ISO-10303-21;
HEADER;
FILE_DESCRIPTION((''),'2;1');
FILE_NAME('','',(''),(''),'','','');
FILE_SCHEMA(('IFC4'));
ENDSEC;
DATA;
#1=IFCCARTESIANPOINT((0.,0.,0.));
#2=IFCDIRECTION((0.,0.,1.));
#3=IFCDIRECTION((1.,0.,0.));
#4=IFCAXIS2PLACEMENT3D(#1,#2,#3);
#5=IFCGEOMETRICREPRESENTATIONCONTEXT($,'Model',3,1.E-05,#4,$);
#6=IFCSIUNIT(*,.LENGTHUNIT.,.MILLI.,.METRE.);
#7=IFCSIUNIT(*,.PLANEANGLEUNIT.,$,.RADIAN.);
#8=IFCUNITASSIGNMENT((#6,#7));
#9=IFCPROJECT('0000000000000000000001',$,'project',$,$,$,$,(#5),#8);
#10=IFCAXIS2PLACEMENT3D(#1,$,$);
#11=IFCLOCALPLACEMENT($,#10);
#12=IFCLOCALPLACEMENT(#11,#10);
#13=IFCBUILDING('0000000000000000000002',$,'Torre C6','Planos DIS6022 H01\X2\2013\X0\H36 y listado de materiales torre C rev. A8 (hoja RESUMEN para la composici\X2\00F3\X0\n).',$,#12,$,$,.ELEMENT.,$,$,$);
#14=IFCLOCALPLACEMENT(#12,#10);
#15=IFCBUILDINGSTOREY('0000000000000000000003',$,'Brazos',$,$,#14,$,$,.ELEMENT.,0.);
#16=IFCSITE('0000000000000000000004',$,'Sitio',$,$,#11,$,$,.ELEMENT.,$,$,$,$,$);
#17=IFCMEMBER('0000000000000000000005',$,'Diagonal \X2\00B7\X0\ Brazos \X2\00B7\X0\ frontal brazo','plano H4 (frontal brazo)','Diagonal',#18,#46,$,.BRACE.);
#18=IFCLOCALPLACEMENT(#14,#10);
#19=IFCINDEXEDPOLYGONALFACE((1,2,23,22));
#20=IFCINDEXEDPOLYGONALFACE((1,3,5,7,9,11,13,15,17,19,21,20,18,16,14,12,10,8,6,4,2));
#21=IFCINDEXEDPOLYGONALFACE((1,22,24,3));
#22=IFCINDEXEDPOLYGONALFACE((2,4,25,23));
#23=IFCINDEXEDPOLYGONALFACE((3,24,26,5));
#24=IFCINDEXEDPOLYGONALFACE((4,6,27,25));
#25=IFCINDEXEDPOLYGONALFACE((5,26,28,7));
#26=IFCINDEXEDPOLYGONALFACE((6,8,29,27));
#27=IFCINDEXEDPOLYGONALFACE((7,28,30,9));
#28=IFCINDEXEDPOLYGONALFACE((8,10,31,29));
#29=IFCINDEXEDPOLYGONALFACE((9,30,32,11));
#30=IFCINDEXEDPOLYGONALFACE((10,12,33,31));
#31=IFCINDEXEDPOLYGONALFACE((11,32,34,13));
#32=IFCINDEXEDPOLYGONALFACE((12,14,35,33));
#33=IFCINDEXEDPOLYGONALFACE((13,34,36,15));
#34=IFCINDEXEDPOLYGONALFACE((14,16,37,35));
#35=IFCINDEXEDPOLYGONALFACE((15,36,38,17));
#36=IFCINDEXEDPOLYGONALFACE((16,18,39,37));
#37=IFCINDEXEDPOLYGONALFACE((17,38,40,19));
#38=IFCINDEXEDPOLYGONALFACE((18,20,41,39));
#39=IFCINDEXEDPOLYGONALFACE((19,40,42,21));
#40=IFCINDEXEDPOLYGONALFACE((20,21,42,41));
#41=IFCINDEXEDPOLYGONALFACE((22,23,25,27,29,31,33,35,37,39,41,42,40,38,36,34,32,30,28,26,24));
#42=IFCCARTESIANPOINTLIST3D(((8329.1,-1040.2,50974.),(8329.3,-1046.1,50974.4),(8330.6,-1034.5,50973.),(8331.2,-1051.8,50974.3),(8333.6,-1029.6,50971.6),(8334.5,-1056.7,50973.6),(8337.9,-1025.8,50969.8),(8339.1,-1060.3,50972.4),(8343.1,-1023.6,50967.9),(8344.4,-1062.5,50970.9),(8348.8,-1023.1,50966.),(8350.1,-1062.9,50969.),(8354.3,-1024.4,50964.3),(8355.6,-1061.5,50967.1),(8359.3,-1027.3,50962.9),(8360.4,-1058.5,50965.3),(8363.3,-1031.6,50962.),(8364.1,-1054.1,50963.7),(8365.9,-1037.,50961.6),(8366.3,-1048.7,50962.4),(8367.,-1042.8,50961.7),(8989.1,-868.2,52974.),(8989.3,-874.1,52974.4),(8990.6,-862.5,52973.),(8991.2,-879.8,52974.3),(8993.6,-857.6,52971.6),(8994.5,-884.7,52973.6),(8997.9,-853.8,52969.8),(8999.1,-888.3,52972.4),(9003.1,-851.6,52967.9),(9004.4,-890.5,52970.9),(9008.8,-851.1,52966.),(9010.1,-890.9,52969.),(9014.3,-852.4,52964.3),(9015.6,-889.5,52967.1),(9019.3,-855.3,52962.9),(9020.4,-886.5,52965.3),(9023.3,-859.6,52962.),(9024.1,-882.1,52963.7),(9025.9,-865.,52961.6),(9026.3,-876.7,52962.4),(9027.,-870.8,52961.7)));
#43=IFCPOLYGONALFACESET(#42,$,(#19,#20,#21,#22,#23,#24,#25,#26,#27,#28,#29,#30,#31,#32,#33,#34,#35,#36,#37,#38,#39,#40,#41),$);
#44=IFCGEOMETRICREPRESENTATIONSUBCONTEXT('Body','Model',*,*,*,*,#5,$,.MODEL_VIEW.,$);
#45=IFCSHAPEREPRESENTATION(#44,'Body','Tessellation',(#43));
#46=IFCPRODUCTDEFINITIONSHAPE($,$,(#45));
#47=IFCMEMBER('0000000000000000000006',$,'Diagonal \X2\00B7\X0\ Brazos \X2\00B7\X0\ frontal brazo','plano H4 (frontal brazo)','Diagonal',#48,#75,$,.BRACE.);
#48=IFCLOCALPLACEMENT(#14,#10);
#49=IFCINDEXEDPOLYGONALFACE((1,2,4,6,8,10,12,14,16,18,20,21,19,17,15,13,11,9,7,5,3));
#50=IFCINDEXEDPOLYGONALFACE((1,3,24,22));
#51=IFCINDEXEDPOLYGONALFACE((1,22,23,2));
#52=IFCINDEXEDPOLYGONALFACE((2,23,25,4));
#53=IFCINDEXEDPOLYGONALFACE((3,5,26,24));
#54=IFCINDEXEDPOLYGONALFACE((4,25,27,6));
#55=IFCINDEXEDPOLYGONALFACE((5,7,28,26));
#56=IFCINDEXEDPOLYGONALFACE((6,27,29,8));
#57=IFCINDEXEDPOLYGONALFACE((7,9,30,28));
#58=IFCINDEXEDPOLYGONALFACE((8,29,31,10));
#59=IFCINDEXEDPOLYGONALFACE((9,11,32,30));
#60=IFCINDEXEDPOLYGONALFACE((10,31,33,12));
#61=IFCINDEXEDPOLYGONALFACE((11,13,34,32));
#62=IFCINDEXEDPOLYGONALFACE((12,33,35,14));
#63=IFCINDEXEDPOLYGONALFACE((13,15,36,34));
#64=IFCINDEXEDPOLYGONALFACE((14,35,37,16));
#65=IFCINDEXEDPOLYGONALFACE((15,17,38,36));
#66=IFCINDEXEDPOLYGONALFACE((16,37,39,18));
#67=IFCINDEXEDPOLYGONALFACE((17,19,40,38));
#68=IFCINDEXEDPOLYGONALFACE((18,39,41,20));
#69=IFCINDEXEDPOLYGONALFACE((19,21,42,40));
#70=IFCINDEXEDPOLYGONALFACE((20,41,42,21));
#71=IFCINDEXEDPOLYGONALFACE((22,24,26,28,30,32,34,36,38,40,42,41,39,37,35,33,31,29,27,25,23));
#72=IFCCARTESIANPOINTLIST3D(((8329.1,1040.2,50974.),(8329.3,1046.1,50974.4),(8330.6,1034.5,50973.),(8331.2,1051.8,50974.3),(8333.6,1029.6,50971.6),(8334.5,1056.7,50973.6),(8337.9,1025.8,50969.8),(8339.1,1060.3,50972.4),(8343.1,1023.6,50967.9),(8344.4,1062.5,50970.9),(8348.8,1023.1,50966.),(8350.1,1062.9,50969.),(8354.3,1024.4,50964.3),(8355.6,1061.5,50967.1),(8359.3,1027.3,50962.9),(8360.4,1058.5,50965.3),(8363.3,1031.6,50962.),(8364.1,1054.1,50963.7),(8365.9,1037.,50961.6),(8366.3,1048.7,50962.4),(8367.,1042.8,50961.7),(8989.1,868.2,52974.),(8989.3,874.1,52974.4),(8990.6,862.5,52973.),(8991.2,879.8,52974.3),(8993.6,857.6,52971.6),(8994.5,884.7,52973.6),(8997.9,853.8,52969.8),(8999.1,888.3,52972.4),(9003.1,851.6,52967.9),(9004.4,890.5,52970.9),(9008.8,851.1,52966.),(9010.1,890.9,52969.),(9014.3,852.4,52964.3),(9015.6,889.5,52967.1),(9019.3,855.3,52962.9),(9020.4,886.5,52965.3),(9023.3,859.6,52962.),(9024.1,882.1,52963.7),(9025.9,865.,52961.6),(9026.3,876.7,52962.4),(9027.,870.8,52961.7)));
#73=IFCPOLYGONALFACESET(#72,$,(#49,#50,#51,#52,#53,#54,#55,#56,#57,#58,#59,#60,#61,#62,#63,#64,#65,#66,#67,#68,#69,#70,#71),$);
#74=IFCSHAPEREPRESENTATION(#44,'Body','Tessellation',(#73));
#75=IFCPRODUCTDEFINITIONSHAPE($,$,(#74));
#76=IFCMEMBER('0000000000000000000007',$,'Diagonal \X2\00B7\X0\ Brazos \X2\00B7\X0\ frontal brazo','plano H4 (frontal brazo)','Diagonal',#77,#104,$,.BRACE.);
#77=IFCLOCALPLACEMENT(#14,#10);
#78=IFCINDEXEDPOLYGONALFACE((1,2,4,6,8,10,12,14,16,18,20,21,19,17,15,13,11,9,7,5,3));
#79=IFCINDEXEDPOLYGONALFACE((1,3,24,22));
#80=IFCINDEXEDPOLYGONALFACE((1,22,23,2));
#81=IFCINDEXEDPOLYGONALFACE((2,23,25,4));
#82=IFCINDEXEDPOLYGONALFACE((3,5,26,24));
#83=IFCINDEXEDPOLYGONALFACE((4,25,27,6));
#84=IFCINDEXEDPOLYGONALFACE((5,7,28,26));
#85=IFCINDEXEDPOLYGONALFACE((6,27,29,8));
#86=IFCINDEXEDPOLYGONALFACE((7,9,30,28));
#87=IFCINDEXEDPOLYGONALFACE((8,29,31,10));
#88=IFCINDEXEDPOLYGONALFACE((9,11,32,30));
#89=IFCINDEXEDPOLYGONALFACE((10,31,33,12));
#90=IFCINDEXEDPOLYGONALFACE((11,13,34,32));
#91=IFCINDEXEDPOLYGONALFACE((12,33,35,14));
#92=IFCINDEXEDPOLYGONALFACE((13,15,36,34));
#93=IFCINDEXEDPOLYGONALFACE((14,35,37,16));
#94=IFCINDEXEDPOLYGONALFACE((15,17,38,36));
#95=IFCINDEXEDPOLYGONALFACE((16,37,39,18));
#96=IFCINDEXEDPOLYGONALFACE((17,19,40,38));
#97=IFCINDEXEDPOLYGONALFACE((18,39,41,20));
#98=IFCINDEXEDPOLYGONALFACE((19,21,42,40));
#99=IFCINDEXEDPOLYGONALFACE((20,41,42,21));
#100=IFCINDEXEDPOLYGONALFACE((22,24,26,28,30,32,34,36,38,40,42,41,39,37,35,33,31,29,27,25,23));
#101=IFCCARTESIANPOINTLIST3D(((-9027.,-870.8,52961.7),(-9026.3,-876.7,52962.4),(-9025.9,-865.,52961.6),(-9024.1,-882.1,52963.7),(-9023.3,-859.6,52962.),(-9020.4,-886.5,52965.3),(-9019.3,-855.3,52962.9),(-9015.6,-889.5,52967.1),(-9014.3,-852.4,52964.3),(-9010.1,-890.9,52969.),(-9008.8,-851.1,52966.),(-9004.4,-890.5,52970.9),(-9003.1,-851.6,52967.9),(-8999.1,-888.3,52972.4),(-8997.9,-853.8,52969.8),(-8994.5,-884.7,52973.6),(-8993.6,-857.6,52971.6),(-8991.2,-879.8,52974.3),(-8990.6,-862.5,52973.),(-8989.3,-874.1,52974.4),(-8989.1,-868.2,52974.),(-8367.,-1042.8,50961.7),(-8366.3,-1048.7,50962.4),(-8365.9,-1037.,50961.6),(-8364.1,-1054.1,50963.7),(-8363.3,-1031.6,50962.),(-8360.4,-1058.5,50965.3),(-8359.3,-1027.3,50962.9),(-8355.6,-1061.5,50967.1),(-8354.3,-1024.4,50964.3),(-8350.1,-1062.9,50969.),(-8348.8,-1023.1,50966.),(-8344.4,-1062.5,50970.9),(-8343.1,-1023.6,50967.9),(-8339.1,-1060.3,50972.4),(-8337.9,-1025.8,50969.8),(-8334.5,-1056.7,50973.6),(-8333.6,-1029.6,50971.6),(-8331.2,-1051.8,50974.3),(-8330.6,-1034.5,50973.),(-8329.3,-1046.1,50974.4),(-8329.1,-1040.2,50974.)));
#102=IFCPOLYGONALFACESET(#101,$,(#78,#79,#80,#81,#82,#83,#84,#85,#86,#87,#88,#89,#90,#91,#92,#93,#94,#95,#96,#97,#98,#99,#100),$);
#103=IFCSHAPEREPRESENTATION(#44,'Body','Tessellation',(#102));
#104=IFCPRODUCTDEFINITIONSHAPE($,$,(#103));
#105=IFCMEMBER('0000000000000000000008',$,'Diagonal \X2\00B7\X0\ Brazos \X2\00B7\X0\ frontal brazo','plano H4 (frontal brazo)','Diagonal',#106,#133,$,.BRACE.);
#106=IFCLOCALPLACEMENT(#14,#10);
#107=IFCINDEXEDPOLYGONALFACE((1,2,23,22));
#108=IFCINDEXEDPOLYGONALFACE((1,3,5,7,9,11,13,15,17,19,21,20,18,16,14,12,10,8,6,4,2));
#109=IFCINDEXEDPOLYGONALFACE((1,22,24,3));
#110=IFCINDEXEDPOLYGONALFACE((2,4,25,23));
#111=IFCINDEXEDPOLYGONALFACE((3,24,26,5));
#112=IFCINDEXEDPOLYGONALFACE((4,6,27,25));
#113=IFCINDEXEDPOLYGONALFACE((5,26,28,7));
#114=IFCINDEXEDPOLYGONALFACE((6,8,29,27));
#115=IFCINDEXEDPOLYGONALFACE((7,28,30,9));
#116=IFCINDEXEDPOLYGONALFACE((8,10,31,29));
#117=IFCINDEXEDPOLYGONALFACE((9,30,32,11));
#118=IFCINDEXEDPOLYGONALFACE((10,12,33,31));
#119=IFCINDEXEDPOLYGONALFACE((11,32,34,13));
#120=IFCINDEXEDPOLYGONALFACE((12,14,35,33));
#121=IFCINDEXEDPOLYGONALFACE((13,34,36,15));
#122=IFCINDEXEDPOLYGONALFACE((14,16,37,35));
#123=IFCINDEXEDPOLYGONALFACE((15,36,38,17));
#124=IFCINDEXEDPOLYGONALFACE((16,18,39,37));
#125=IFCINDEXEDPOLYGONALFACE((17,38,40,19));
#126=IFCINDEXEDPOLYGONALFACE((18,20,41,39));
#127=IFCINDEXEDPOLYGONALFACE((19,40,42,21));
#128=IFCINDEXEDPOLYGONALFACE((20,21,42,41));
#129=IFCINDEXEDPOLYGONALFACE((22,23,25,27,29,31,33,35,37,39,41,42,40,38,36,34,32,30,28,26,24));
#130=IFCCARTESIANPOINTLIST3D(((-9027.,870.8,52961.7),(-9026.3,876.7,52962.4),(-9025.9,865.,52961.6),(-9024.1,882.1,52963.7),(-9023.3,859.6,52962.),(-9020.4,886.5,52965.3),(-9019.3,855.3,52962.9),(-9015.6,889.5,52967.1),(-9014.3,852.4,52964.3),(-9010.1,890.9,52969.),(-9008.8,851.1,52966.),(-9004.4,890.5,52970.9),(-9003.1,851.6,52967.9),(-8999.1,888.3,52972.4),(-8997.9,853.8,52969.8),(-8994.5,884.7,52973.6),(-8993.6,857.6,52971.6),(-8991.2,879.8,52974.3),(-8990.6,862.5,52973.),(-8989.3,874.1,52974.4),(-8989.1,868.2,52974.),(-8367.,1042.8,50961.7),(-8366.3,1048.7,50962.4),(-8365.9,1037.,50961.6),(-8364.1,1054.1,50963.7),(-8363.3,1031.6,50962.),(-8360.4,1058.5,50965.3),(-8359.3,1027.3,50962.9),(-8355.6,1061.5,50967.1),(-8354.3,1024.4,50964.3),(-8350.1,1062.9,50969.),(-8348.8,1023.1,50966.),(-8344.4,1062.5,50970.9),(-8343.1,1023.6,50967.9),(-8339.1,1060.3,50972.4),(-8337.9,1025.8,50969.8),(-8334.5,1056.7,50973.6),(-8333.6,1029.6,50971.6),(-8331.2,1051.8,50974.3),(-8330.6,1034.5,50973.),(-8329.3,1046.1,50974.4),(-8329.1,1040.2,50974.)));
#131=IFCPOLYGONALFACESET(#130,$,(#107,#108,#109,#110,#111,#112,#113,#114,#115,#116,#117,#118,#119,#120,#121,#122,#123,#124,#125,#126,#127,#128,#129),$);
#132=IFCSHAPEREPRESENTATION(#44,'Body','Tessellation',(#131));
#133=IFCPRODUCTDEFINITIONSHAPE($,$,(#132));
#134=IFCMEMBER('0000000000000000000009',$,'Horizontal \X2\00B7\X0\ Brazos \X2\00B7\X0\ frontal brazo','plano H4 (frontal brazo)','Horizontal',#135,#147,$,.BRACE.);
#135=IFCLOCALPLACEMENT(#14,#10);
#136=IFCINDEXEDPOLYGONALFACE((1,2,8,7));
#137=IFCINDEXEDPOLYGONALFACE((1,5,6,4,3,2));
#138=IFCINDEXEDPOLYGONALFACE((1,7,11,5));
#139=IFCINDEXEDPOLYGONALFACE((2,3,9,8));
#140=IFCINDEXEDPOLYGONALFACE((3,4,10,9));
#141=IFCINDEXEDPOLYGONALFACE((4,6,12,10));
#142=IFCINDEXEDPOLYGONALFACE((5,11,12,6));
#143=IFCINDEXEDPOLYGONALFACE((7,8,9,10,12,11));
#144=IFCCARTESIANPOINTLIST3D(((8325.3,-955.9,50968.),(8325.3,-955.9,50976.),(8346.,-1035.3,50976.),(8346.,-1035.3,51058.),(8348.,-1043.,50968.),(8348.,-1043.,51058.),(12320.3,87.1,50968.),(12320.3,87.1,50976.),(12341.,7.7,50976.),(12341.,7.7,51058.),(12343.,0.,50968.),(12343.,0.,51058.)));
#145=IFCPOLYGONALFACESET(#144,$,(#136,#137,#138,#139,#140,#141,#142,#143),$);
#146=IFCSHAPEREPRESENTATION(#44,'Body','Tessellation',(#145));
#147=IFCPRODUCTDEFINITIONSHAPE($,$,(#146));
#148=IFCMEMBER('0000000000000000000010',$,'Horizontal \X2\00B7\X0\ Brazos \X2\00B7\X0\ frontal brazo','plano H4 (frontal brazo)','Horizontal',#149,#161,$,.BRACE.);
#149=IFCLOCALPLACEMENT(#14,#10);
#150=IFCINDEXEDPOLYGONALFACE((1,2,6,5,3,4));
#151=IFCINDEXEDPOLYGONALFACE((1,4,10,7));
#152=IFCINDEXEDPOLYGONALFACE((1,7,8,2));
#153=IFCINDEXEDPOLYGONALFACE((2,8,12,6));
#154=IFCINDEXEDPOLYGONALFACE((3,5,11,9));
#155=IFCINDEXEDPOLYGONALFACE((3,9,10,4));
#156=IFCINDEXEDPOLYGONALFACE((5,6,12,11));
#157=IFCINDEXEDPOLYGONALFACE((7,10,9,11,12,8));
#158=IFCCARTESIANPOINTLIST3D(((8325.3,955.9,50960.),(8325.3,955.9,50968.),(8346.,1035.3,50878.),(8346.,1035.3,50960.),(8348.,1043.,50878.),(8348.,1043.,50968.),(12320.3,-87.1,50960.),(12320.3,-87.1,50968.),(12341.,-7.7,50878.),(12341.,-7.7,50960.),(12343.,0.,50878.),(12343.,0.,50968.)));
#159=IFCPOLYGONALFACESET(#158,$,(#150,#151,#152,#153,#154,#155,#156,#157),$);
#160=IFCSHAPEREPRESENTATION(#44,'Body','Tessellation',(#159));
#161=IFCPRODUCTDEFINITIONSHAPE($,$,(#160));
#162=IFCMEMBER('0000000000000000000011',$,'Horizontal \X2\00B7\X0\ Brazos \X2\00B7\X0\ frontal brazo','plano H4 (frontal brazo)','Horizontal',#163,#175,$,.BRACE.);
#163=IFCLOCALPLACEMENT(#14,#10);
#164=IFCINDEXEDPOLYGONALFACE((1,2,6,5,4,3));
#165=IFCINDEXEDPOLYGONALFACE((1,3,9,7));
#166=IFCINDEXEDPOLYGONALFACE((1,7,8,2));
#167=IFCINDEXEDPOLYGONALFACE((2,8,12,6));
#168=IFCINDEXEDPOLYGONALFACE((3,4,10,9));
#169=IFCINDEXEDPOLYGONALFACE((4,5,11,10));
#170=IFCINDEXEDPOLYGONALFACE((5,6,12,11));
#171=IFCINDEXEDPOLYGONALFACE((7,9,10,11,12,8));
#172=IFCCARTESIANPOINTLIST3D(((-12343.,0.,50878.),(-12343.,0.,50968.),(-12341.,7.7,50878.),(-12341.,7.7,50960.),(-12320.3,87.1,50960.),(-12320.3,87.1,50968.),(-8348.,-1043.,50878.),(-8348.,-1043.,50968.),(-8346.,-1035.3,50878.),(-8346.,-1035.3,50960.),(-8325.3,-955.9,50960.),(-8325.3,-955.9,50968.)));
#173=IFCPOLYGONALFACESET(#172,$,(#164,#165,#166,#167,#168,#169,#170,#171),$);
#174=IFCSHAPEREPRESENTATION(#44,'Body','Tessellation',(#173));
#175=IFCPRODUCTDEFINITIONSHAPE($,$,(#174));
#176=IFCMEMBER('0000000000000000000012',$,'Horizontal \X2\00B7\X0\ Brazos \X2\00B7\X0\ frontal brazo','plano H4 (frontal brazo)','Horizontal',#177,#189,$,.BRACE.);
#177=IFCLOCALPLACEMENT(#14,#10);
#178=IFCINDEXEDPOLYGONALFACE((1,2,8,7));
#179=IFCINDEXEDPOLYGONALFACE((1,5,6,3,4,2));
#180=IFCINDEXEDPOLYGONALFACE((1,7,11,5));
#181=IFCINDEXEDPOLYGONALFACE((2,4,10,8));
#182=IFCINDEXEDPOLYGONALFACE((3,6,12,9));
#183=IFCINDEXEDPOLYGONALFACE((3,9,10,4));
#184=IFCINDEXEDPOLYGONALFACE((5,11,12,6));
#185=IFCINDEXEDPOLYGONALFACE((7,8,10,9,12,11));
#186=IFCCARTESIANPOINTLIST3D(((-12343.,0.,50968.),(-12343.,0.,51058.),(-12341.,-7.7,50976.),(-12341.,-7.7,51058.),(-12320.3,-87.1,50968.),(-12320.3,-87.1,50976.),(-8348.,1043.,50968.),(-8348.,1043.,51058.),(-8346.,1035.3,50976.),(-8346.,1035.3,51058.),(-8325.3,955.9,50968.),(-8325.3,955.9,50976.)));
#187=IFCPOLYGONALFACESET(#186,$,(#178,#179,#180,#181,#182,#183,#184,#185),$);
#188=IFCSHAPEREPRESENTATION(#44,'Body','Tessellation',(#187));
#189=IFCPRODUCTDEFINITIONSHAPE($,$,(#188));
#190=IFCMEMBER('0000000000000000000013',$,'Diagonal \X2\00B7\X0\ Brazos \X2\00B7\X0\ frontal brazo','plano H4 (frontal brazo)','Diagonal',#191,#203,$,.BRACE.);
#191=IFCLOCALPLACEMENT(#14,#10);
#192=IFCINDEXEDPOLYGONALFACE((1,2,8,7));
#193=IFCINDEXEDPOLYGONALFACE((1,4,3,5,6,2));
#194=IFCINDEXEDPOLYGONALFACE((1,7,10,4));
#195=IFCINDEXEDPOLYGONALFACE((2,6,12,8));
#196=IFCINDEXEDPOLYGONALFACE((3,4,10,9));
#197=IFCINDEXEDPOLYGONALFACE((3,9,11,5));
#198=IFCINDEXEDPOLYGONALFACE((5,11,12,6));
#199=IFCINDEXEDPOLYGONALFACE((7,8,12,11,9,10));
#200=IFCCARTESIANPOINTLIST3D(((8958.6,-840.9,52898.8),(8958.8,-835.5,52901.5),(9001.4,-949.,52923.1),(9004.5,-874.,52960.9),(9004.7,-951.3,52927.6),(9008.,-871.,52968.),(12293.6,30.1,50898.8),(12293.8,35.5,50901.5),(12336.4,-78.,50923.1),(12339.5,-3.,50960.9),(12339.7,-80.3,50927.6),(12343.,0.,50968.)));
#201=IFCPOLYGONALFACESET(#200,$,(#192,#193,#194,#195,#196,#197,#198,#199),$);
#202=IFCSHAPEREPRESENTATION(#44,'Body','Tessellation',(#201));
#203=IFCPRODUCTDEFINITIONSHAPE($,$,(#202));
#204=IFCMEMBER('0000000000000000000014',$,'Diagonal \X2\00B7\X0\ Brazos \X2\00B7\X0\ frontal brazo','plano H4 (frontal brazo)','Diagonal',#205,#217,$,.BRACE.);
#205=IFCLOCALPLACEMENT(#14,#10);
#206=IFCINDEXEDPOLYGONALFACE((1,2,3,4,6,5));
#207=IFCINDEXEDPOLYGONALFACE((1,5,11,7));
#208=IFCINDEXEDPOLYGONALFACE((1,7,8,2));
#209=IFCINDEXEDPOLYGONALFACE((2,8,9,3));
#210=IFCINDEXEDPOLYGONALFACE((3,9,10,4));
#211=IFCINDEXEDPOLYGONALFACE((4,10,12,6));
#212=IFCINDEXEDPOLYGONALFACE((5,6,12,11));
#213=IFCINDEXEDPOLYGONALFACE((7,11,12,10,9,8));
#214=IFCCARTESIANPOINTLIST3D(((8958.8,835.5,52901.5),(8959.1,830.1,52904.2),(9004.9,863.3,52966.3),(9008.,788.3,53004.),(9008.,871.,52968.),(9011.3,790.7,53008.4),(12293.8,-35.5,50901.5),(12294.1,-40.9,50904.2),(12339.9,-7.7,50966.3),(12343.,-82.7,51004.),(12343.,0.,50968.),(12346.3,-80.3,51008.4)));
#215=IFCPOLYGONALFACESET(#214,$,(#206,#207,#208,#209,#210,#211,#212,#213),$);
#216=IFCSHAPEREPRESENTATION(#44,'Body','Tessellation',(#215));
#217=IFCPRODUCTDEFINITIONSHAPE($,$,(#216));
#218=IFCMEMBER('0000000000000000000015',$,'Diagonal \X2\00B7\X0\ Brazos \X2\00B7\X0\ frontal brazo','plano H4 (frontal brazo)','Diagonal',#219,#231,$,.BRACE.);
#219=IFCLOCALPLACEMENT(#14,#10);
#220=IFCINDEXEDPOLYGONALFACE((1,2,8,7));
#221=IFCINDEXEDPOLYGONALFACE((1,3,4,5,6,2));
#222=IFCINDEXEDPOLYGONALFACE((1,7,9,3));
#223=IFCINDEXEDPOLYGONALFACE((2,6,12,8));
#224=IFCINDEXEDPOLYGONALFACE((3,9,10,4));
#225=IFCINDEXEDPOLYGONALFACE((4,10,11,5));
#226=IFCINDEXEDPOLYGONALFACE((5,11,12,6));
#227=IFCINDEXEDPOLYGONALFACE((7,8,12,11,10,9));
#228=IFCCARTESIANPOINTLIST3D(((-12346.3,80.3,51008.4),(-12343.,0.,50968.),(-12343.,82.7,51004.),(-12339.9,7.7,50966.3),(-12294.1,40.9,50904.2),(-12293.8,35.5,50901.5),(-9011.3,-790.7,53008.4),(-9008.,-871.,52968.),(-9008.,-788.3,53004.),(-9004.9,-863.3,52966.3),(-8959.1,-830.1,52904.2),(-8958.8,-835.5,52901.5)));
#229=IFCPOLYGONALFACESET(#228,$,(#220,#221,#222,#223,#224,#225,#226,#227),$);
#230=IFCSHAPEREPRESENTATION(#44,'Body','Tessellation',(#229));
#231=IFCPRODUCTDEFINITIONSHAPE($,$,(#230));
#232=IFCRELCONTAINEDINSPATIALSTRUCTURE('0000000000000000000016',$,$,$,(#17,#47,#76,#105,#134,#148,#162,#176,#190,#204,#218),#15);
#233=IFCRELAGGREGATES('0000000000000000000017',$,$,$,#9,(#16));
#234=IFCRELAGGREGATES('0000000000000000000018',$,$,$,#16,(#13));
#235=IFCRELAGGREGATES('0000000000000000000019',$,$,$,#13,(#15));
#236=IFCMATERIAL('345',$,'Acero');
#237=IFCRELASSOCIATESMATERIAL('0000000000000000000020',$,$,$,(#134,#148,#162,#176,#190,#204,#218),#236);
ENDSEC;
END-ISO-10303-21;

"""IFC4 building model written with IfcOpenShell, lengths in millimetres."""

from ifc_helpers import new_model, si_unit, frame, frame_2d, origin, origin_with_axes, place, context, subcontext, project, spatial, circle, l_section, extrude, material, element, save


model = new_model("IFC4")

# Units and contexts
model_context = context("Model", 3, precision=1e-05, world=origin_with_axes())
body_context = subcontext(model_context, "Body", "Model", "MODEL_VIEW")
ifc_project = project(units=[si_unit("LENGTHUNIT", "METRE", prefix="MILLI"), si_unit("PLANEANGLEUNIT", "RADIAN")], contexts=[model_context])

# Site, building, storey
site_placement = place(None, origin())
site = spatial("IfcSite", under=ifc_project, at=site_placement, Name="Sitio", CompositionType="ELEMENT")
building_placement = place(site_placement, origin())
building = spatial("IfcBuilding", under=site, at=building_placement, Name="Torre C6", Description="Planos DIS6022 H01–H36 y listado de materiales torre C rev. A8 (hoja RESUMEN para la composición).", CompositionType="ELEMENT")
storey_placement = place(building_placement, origin())
storey = spatial("IfcBuildingStorey", under=building, at=storey_placement, Name="Brazos", CompositionType="ELEMENT", Elevation=0.0)

# Members
for number, where, z_axis, x_axis, name in (
    (1, (8348.0, -1043.0, 50968.0), (0.312338, 0.081397, 0.946478), (-0.943719, 0.140707, 0.299326), "Diagonal · Brazos · frontal brazo"),
    (2, (8348.0, 1043.0, 50968.0), (0.312338, -0.081397, 0.946478), (-0.943719, -0.140707, 0.299326), "Diagonal · Brazos · frontal brazo"),
    (3, (-8348.0, -1043.0, 50968.0), (-0.312338, 0.081397, 0.946478), (0.943719, 0.140707, 0.299326), "Diagonal · Brazos · frontal brazo"),
    (4, (-8348.0, 1043.0, 50968.0), (-0.312338, -0.081397, 0.946478), (0.943719, -0.140707, 0.299326), "Diagonal · Brazos · frontal brazo"),
):
    element("IfcMember", number, at=place(storey_placement, frame(where, z_axis=z_axis, x_axis=x_axis)), inside=storey, Name=name, Description="plano H4 (frontal brazo)", ObjectType="Diagonal", PredefinedType="BRACE", context=body_context, shape_type="SweptSolid", body=[
        extrude(circle(Radius=20.0), None, (0.0, 0.0, 1.0), 2113.1),
    ])
ifc_material_1 = material(Name="345", Category="Acero")
for number, where, z_axis, x_axis, name in (
    (5, (8348.0, -1043.0, 50968.0), (0.967568, 0.252609, 0.0), (-0.252609, 0.967568, 0.0), "Horizontal · Brazos · frontal brazo"),
    (6, (8348.0, 1043.0, 50968.0), (0.967568, -0.252609, 0.0), (-0.252609, -0.967568, 0.0), "Horizontal · Brazos · frontal brazo"),
    (7, (-8348.0, -1043.0, 50968.0), (-0.967568, 0.252609, 0.0), (0.252609, 0.967568, 0.0), "Horizontal · Brazos · frontal brazo"),
    (8, (-8348.0, 1043.0, 50968.0), (-0.967568, -0.252609, 0.0), (0.252609, -0.967568, 0.0), "Horizontal · Brazos · frontal brazo"),
):
    element("IfcMember", number, at=place(storey_placement, frame(where, z_axis=z_axis, x_axis=x_axis)), inside=storey, material=ifc_material_1, Name=name, Description="plano H4 (frontal brazo)", ObjectType="Horizontal", PredefinedType="BRACE", context=body_context, shape_type="SweptSolid", body=[
        extrude(l_section(Depth=90.0, Width=90.0, Thickness=8.0, at=frame_2d((45.0, 45.0))), None, (0.0, 0.0, 1.0), 4128.9),
    ])
for number, where, z_axis, x_axis, name in (
    (9, (12343.0, 0.0, 50968.0), (-0.836871, -0.218565, 0.501872), (-0.546187, 0.394391, -0.73901), "Diagonal · Brazos · frontal brazo"),
    (10, (12343.0, 0.0, 50968.0), (-0.836871, 0.218565, 0.501872), (-0.546187, -0.394391, -0.73901), "Diagonal · Brazos · frontal brazo"),
    (11, (-12343.0, 0.0, 50968.0), (0.836871, -0.218565, 0.501872), (0.546187, 0.394391, -0.73901), "Diagonal · Brazos · frontal brazo"),
):
    element("IfcMember", number, at=place(storey_placement, frame(where, z_axis=z_axis, x_axis=x_axis)), inside=storey, material=ifc_material_1, Name=name, Description="plano H4 (frontal brazo)", ObjectType="Diagonal", PredefinedType="BRACE", context=body_context, shape_type="SweptSolid", body=[
        extrude(l_section(Depth=90.0, Width=90.0, Thickness=6.0, at=frame_2d((45.0, 45.0))), None, (0.0, 0.0, 1.0), 3985.1),
    ])

save(model, "model.ifc")
